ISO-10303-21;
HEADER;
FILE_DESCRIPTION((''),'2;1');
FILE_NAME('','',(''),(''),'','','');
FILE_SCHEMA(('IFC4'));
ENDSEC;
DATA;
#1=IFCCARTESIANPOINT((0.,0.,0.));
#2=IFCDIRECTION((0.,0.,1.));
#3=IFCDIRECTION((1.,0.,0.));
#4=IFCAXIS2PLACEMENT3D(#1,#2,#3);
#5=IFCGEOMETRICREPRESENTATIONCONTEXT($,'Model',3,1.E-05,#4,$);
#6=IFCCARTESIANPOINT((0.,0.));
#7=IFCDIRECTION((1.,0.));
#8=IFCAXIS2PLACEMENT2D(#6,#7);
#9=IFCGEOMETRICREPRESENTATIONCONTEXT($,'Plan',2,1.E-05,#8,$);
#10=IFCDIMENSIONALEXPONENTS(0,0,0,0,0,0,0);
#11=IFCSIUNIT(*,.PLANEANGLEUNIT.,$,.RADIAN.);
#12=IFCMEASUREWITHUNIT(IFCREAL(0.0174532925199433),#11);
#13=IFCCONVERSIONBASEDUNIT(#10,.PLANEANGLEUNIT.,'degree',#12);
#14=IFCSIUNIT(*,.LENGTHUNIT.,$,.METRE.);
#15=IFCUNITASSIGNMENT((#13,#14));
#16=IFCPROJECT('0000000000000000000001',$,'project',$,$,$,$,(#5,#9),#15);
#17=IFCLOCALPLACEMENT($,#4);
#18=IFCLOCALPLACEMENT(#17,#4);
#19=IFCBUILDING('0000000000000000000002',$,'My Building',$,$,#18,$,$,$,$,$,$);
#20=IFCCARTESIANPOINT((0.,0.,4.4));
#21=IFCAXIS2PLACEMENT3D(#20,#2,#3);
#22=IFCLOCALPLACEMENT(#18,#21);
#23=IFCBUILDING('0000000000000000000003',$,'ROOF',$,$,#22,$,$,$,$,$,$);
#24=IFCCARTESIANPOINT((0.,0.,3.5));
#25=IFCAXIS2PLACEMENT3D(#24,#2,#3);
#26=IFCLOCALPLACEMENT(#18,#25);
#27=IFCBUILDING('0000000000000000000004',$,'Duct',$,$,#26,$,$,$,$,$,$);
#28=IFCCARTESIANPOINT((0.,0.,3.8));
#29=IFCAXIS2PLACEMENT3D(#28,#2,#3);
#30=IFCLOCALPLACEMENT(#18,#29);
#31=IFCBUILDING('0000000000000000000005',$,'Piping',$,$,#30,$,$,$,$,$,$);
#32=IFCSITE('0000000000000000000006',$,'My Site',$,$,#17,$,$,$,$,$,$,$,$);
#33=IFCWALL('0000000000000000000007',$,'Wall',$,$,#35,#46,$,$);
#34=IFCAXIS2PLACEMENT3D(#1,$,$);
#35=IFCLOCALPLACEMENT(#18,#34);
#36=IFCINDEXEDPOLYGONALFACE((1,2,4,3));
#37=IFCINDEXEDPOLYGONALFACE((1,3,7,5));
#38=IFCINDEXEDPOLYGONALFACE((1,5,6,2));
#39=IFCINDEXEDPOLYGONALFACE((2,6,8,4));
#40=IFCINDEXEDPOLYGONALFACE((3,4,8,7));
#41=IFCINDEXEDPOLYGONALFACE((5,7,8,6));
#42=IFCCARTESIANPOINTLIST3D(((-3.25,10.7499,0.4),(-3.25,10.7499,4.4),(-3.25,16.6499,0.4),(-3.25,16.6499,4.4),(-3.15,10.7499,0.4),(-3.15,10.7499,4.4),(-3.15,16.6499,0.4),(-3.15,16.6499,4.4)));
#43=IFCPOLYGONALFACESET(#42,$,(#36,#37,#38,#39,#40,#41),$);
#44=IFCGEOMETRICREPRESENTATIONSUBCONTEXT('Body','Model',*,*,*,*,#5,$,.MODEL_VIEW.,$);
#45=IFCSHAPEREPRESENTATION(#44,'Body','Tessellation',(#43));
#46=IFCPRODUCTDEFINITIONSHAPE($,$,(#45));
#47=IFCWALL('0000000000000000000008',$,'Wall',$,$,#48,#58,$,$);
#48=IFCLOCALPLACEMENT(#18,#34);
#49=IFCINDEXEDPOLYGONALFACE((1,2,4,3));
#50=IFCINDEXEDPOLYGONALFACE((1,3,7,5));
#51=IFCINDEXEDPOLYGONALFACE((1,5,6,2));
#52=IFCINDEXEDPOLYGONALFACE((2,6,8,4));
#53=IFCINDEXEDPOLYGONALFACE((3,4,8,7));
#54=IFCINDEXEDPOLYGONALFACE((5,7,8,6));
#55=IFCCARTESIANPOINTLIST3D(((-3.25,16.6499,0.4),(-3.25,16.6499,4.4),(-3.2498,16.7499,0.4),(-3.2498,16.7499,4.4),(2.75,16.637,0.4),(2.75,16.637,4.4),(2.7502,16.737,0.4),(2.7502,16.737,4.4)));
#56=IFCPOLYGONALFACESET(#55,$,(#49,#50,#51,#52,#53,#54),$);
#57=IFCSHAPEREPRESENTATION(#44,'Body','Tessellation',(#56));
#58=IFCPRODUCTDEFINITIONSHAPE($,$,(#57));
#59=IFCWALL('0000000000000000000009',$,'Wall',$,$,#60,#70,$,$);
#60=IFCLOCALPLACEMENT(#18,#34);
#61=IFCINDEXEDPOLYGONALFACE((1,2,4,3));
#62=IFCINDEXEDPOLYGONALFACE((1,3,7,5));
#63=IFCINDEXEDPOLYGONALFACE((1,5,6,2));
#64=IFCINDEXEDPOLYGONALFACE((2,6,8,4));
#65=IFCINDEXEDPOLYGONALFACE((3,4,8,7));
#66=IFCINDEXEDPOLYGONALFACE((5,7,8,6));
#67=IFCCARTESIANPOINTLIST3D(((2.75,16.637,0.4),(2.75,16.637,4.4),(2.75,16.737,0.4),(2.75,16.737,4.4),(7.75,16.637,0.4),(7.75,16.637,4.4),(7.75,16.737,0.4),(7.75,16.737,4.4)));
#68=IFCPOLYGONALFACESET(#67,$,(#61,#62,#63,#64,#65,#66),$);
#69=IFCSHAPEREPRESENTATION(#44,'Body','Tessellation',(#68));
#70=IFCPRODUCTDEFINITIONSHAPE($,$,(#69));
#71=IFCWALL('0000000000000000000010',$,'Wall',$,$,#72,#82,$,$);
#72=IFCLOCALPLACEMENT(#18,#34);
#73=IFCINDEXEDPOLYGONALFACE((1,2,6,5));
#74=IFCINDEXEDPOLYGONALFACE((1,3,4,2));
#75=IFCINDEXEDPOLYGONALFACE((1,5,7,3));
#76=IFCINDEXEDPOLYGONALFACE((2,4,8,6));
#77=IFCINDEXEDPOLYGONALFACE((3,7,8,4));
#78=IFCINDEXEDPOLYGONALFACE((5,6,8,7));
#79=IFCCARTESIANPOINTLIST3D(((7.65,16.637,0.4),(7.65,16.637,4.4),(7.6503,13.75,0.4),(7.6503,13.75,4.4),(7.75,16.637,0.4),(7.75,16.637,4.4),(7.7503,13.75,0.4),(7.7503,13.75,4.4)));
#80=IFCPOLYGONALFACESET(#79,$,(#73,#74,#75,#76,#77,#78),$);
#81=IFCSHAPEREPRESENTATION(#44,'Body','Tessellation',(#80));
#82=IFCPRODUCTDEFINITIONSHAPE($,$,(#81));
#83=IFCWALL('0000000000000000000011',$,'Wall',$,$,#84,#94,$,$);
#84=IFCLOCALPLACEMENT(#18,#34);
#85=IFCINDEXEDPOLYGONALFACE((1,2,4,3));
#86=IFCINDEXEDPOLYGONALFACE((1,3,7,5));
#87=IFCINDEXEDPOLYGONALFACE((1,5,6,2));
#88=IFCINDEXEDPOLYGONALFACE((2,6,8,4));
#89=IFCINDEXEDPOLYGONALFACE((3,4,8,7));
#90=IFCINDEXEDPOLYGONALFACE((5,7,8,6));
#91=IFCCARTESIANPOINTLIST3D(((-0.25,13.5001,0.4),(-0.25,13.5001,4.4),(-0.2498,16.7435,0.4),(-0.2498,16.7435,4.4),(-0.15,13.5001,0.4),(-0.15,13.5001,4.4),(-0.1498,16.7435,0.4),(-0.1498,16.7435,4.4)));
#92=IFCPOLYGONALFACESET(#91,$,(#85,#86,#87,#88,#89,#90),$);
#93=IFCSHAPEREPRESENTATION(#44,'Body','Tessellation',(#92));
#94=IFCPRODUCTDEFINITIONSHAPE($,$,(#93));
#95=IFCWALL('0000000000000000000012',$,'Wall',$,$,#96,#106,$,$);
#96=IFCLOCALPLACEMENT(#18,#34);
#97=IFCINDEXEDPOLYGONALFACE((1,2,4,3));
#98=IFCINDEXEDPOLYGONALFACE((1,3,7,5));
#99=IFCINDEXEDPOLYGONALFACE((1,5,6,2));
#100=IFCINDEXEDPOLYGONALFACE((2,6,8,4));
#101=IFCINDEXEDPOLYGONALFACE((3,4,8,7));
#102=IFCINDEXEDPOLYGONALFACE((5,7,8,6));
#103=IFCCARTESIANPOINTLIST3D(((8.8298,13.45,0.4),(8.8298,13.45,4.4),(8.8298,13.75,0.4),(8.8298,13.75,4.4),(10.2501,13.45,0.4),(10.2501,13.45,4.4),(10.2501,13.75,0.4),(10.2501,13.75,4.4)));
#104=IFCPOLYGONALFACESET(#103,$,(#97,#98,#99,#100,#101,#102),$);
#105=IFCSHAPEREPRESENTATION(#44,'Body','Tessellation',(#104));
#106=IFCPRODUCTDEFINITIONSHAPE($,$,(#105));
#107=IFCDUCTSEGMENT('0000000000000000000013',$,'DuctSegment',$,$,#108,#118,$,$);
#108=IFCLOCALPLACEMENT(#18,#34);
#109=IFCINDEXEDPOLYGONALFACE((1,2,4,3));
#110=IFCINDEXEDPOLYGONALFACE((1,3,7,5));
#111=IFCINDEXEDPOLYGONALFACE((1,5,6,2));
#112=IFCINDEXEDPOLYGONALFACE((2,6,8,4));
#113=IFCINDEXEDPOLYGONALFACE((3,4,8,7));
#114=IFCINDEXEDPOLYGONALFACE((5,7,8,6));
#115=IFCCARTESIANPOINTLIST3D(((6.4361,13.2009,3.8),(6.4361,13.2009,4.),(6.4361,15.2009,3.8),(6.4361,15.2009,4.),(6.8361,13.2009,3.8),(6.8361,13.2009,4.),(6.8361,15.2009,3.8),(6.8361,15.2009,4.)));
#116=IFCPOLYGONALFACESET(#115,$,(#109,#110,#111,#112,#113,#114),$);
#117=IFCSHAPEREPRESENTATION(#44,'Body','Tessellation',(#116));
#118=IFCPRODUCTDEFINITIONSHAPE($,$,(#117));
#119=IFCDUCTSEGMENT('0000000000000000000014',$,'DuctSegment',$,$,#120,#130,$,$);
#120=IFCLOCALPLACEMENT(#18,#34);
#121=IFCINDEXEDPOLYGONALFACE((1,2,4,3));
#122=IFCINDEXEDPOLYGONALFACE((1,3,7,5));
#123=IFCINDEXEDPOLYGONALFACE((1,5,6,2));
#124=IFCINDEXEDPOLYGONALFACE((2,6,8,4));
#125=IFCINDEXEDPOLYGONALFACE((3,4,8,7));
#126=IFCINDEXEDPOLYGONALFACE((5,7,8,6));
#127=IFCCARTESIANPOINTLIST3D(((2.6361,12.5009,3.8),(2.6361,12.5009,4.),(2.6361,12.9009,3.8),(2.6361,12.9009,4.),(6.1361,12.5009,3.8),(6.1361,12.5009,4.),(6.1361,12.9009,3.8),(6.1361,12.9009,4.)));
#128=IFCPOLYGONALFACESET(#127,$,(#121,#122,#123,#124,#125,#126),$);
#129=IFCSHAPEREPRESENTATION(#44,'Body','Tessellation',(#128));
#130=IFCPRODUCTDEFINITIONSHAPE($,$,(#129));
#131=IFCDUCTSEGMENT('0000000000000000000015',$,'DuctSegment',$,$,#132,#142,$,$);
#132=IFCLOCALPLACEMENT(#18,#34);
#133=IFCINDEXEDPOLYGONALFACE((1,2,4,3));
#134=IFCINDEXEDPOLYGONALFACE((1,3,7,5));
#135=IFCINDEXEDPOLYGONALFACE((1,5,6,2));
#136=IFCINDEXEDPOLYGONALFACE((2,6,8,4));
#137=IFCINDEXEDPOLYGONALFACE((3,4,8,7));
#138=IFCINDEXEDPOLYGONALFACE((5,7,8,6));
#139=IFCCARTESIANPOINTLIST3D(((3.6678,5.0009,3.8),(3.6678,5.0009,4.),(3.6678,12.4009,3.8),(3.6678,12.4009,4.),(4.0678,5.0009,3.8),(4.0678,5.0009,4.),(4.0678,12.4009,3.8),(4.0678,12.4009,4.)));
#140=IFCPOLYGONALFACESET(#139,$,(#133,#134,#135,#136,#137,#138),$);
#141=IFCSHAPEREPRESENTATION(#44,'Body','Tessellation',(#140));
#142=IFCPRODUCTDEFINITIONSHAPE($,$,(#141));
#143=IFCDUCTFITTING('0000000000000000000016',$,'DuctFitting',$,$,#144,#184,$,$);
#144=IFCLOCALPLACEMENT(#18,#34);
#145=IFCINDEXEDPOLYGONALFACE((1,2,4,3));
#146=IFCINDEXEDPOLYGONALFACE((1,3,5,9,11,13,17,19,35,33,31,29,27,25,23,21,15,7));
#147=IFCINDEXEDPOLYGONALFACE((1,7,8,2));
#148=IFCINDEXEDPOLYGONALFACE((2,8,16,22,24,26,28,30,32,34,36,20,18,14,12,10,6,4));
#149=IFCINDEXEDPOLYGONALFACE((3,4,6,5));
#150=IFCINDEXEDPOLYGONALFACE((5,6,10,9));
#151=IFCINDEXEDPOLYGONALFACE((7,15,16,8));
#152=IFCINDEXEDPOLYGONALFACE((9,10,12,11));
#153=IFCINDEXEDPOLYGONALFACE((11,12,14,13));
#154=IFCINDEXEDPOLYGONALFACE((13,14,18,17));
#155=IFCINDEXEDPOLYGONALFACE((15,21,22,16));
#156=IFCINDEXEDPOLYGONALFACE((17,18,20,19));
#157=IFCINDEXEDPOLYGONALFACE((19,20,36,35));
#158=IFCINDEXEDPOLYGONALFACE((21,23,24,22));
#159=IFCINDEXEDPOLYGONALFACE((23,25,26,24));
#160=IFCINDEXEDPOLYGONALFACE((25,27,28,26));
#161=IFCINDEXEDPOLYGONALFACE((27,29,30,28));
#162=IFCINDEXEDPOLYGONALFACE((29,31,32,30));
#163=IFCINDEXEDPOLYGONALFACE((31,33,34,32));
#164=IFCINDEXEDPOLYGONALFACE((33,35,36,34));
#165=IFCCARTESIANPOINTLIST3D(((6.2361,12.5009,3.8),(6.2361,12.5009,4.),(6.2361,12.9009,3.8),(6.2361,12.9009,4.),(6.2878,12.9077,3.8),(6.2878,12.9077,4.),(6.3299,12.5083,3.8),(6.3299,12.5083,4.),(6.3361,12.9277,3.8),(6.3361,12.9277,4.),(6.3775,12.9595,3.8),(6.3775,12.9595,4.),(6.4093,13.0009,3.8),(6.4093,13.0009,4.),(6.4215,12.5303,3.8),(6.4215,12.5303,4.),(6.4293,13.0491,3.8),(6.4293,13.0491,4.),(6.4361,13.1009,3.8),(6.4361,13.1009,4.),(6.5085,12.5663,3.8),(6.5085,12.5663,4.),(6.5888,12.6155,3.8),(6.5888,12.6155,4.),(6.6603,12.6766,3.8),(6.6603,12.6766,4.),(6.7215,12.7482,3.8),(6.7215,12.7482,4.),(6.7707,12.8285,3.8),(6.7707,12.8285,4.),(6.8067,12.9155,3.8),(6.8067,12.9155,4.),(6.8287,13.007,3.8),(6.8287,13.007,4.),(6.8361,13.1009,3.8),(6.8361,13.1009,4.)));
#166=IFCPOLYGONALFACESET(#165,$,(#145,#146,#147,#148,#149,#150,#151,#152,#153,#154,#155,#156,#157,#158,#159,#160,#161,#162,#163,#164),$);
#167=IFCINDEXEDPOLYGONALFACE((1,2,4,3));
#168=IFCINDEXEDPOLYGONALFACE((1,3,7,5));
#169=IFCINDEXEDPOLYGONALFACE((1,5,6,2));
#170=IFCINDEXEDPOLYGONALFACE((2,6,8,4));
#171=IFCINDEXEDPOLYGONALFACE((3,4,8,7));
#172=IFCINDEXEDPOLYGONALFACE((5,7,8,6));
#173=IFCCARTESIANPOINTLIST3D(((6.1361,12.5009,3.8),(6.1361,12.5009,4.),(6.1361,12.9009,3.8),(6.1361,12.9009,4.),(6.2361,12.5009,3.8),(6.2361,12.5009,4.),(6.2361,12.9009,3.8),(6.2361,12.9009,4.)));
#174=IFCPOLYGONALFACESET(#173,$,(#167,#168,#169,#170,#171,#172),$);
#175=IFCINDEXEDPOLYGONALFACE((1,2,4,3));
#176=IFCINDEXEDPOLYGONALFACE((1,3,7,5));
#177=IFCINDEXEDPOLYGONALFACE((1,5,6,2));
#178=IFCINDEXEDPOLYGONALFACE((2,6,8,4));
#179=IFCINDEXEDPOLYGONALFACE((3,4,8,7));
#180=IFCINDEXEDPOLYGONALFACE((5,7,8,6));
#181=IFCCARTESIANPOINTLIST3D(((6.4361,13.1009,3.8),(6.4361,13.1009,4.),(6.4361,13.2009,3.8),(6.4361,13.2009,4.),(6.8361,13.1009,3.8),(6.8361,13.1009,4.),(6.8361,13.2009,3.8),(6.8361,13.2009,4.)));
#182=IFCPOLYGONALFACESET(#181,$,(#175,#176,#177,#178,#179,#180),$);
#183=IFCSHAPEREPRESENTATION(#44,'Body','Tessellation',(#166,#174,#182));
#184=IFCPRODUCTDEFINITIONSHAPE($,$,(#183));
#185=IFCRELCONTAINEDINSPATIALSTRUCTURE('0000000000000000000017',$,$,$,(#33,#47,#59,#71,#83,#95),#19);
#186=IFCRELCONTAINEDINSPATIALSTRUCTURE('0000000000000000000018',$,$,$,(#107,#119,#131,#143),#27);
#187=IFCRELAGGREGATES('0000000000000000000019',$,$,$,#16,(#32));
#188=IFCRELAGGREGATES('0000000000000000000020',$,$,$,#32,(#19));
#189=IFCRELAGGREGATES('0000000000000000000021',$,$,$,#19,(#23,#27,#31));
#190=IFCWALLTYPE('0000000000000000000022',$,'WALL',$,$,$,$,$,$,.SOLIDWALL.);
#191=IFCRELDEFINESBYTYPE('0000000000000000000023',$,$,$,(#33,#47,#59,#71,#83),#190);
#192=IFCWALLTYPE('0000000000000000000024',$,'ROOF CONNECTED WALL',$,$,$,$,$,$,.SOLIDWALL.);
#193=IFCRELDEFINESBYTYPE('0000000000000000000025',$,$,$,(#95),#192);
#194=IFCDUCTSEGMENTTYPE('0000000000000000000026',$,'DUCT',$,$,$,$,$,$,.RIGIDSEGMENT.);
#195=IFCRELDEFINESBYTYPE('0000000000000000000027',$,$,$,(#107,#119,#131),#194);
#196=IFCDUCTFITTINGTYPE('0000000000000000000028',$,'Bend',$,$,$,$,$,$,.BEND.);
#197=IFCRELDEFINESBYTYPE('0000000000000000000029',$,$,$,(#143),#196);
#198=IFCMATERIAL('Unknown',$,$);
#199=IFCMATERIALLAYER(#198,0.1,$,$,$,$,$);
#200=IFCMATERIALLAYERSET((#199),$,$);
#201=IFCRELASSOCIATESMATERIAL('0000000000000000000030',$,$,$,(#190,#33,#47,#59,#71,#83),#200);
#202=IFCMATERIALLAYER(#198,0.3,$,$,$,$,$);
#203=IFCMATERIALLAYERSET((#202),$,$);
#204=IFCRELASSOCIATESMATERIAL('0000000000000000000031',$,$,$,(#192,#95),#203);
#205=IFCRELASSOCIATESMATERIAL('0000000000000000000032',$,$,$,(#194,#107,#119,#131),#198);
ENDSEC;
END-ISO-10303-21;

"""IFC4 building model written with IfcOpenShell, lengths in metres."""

from ifc_helpers import new_model, entity, si_unit, converted_unit, frame, origin_with_axes, origin_2d_with_axis, place, context, subcontext, project, spatial, line, arc, indexed_curve, rectangle, outline, extrude, source, transform, mapped, material, layer, layer_set, layer_usage, material_profile, profile_set, profile_usage, type_object, type_shapes, element, save


model = new_model("IFC4")

# Units and contexts
model_context = context("Model", 3, precision=1e-05, world=origin_with_axes())
plan_context = context("Plan", 2, precision=1e-05, world=origin_2d_with_axis())
body_context_1 = subcontext(model_context, "Body", "Model", "MODEL_VIEW")
ifc_project = project(units=[converted_unit("PLANEANGLEUNIT", "degree", entity("IfcReal", 0.0174532925199433), si_unit("PLANEANGLEUNIT", "RADIAN"), dimensions=[0, 0, 0, 0, 0, 0, 0]), si_unit("LENGTHUNIT", "METRE")], contexts=[model_context, plan_context])

# Site, building
site_placement = place(None, origin_with_axes())
site = spatial("IfcSite", under=ifc_project, at=site_placement, Name="My Site")
building_1_placement = place(site_placement, origin_with_axes())
building_1 = spatial("IfcBuilding", under=site, at=building_1_placement, Name="My Building")

# Shared definitions
ifc_material = material(Name="Unknown")

# Shared definitions
building_2_placement = place(building_1_placement, frame((0.0, 0.0, 4.4), z_axis=(0.0, 0.0, 1.0), x_axis=(1.0, 0.0, 0.0)))
building_2 = spatial("IfcBuilding", under=building_1, at=building_2_placement, Name="ROOF")

# Shared definitions
ifc_layer_1 = layer(ifc_material, 0.1)
ifc_layer_set_1 = layer_set([ifc_layer_1])
wall_type_1 = type_object("IfcWallType", Name="WALL", PredefinedType="SOLIDWALL", material=ifc_layer_set_1)

# Walls
ifc_layer_usage_1 = layer_usage(ifc_layer_set_1, "AXIS2", "POSITIVE", 0.0)
wall_1_placement = place(building_1_placement, frame((-3.15, 10.7499, 0.4), z_axis=(0.0, 0.0, 1.0), x_axis=(0.0, 1.0, 0.0)))
element("IfcWall", 1, at=wall_1_placement, inside=building_1, type_object=wall_type_1, material=ifc_layer_usage_1, Name="Wall", context=body_context_1, shape_type="SweptSolid", body=[
    extrude(outline(indexed_curve([(0.0, 0.0), (0.0, 0.1), (5.9, 0.1), (5.9, 0.0)], segments=[line(1, 2, 3, 4, 1)])), origin_with_axes(), (0.0, 0.0, 1.0), 4.0),
])
ifc_layer_usage_2 = layer_usage(ifc_layer_set_1, "AXIS2", "POSITIVE", 0.0)
wall_2_placement = place(building_1_placement, frame((-3.25, 16.6499, 0.4), z_axis=(0.0, 0.0, 1.0), x_axis=(0.999998, -0.002154, 0.0)))
element("IfcWall", 2, at=wall_2_placement, inside=building_1, type_object=wall_type_1, material=ifc_layer_usage_2, Name="Wall", context=body_context_1, shape_type="SweptSolid", body=[
    extrude(outline(indexed_curve([(0.0, 0.0), (0.0, 0.1), (6.0, 0.1), (6.0, 0.0)], segments=[line(1, 2, 3, 4, 1)])), origin_with_axes(), (0.0, 0.0, 1.0), 4.0),
])
ifc_layer_usage_3 = layer_usage(ifc_layer_set_1, "AXIS2", "POSITIVE", 0.0)
wall_3_placement = place(building_1_placement, frame((2.75, 16.637, 0.4), z_axis=(0.0, 0.0, 1.0), x_axis=(1.0, 0.0, 0.0)))
element("IfcWall", 3, at=wall_3_placement, inside=building_1, type_object=wall_type_1, material=ifc_layer_usage_3, Name="Wall", context=body_context_1, shape_type="SweptSolid", body=[
    extrude(outline(indexed_curve([(0.0, 0.0), (0.0, 0.1), (5.0, 0.1), (5.0, 0.0)], segments=[line(1, 2, 3, 4, 1)])), origin_with_axes(), (0.0, 0.0, 1.0), 4.0),
])
ifc_layer_usage_4 = layer_usage(ifc_layer_set_1, "AXIS2", "POSITIVE", 0.0)
wall_4_placement = place(building_1_placement, frame((7.65, 16.637, 0.4), z_axis=(0.0, 0.0, 1.0), x_axis=(0.000091, -1.0, 0.0)))
element("IfcWall", 4, at=wall_4_placement, inside=building_1, type_object=wall_type_1, material=ifc_layer_usage_4, Name="Wall", context=body_context_1, shape_type="SweptSolid", body=[
    extrude(outline(indexed_curve([(0.0, 0.0), (0.0, 0.1), (2.887, 0.1), (2.887, 0.0)], segments=[line(1, 2, 3, 4, 1)])), origin_with_axes(), (0.0, 0.0, 1.0), 4.0),
])
ifc_layer_usage_5 = layer_usage(ifc_layer_set_1, "AXIS2", "POSITIVE", 0.0)
wall_5_placement = place(building_1_placement, frame((-0.15, 13.5001, 0.4), z_axis=(0.0, 0.0, 1.0), x_axis=(0.000067, 1.0, 0.0)))
element("IfcWall", 5, at=wall_5_placement, inside=building_1, type_object=wall_type_1, material=ifc_layer_usage_5, Name="Wall", context=body_context_1, shape_type="SweptSolid", body=[
    extrude(outline(indexed_curve([(0.0, 0.0), (0.0, 0.1), (3.2434, 0.1), (3.2434, 0.0)], segments=[line(1, 2, 3, 4, 1)])), origin_with_axes(), (0.0, 0.0, 1.0), 4.0),
])
ifc_layer_2 = layer(ifc_material, 0.3)
ifc_layer_set_2 = layer_set([ifc_layer_2])
ifc_layer_usage_6 = layer_usage(ifc_layer_set_2, "AXIS2", "POSITIVE", 0.0)
wall_type_2 = type_object("IfcWallType", Name="ROOF CONNECTED WALL", PredefinedType="SOLIDWALL", material=ifc_layer_set_2)
wall_6_placement = place(building_1_placement, frame((8.8298, 13.45, 0.4), z_axis=(0.0, 0.0, 1.0), x_axis=(1.0, 0.0, 0.0)))
element("IfcWall", 6, at=wall_6_placement, inside=building_1, type_object=wall_type_2, material=ifc_layer_usage_6, Name="Wall", context=body_context_1, shape_type="SweptSolid", body=[
    extrude(outline(indexed_curve([(0.0, 0.0), (0.0, 0.3), (1.4203, 0.3), (1.4203, 0.0)], segments=[line(1, 2, 3, 4, 1)])), origin_with_axes(), (0.0, 0.0, 1.0), 4.0),
])

# Shared definitions
building_3_placement = place(building_1_placement, frame((0.0, 0.0, 3.5), z_axis=(0.0, 0.0, 1.0), x_axis=(1.0, 0.0, 0.0)))
building_3 = spatial("IfcBuilding", under=building_1, at=building_3_placement, Name="Duct")

# Duct segments
ifc_material_profile_1 = material_profile(ifc_material, rectangle(XDim=0.4, YDim=0.2))
ifc_profile_set_1 = profile_set([ifc_material_profile_1])
ifc_profile_usage_1 = profile_usage(ifc_profile_set_1, cardinal=5)
duct_segment_type = type_object("IfcDuctSegmentType", Name="DUCT", PredefinedType="RIGIDSEGMENT", material=ifc_profile_set_1)
duct_segment_1_placement = place(building_3_placement, frame((6.6361, 15.2009, 0.4), z_axis=(0.0, -1.0, 0.0), x_axis=(1.0, 0.0, 0.0)))
element("IfcDuctSegment", 7, at=duct_segment_1_placement, inside=building_3, type_object=duct_segment_type, material=ifc_profile_usage_1, Name="DuctSegment", context=body_context_1, shape_type="SweptSolid", body=[
    extrude(rectangle(XDim=0.4, YDim=0.2), origin_with_axes(), (0.0, 0.0, 1.0), 2.0),
])
ifc_profile_usage_2 = profile_usage(ifc_profile_set_1, cardinal=5)
duct_segment_2_placement = place(building_3_placement, frame((6.1361, 12.7009, 0.4), z_axis=(-1.0, 0.0, 0.0), x_axis=(0.0, -1.0, 0.0)))
element("IfcDuctSegment", 8, at=duct_segment_2_placement, inside=building_3, type_object=duct_segment_type, material=ifc_profile_usage_2, Name="DuctSegment", context=body_context_1, shape_type="SweptSolid", body=[
    extrude(rectangle(XDim=0.4, YDim=0.2), origin_with_axes(), (0.0, 0.0, 1.0), 3.5),
])
ifc_profile_usage_3 = profile_usage(ifc_profile_set_1, cardinal=5)
duct_segment_3_placement = place(building_3_placement, frame((3.8678, 12.4009, 0.4), z_axis=(0.0, -1.0, 0.0), x_axis=(1.0, 0.0, 0.0)))
element("IfcDuctSegment", 9, at=duct_segment_3_placement, inside=building_3, type_object=duct_segment_type, material=ifc_profile_usage_3, Name="DuctSegment", context=body_context_1, shape_type="SweptSolid", body=[
    extrude(rectangle(XDim=0.4, YDim=0.2), origin_with_axes(), (0.0, 0.0, 1.0), 7.4),
])

# Duct fitting
duct_fitting_type_1 = type_object("IfcDuctFittingType", Name="Bend", PredefinedType="BEND")
shared_shape_1 = source(origin_with_axes(), body_context_1, "Body", "SweptSolid", [
    extrude(outline(indexed_curve([(0.2, 0.0), (0.2586, -0.1414), (0.4, -0.2), (0.4, -0.6), (-0.0243, -0.4243), (-0.2, 0.0)], segments=[arc(1, 2, 3), line(3, 4), arc(4, 5, 6), line(6, 1)])), frame((0.0, -0.1, -0.1), z_axis=(0.0, -1.0, 0.0), x_axis=(1.0, 0.0, 0.0)), (0.0, 0.0, -1.0), 0.2),
    extrude(rectangle(XDim=0.4, YDim=0.2), origin_with_axes(), (0.0, 0.0, -1.0), 0.1),
    extrude(rectangle(XDim=0.4, YDim=0.2), frame((0.4, 0.0, -0.5), z_axis=(1.0, 0.0, 0.0), x_axis=(0.0, 0.0, 1.0)), (0.0, 0.0, 1.0), 0.1),
])
type_shapes(duct_fitting_type_1, [shared_shape_1])
duct_fitting_1_placement = place(building_3_placement, frame((6.1361, 12.7009, 0.4), z_axis=(-1.0, 0.0, 0.0), x_axis=(0.0, 1.0, 0.0)))
element("IfcDuctFitting", 10, at=duct_fitting_1_placement, inside=building_3, type_object=duct_fitting_type_1, Name="DuctFitting", context=body_context_1, shape_type="MappedRepresentation", body=[
    mapped(shared_shape_1, transform((0.0, 0.0, 0.0), x_axis=(1.0, 0.0, 0.0), y_axis=(0.0, 1.0, 0.0), z_axis=(0.0, 0.0, 1.0), scale=1.0)),
])

# Shared definitions
building_4_placement = place(building_1_placement, frame((0.0, 0.0, 3.8), z_axis=(0.0, 0.0, 1.0), x_axis=(1.0, 0.0, 0.0)))
building_4 = spatial("IfcBuilding", under=building_1, at=building_4_placement, Name="Piping")

save(model, "model.ifc")
